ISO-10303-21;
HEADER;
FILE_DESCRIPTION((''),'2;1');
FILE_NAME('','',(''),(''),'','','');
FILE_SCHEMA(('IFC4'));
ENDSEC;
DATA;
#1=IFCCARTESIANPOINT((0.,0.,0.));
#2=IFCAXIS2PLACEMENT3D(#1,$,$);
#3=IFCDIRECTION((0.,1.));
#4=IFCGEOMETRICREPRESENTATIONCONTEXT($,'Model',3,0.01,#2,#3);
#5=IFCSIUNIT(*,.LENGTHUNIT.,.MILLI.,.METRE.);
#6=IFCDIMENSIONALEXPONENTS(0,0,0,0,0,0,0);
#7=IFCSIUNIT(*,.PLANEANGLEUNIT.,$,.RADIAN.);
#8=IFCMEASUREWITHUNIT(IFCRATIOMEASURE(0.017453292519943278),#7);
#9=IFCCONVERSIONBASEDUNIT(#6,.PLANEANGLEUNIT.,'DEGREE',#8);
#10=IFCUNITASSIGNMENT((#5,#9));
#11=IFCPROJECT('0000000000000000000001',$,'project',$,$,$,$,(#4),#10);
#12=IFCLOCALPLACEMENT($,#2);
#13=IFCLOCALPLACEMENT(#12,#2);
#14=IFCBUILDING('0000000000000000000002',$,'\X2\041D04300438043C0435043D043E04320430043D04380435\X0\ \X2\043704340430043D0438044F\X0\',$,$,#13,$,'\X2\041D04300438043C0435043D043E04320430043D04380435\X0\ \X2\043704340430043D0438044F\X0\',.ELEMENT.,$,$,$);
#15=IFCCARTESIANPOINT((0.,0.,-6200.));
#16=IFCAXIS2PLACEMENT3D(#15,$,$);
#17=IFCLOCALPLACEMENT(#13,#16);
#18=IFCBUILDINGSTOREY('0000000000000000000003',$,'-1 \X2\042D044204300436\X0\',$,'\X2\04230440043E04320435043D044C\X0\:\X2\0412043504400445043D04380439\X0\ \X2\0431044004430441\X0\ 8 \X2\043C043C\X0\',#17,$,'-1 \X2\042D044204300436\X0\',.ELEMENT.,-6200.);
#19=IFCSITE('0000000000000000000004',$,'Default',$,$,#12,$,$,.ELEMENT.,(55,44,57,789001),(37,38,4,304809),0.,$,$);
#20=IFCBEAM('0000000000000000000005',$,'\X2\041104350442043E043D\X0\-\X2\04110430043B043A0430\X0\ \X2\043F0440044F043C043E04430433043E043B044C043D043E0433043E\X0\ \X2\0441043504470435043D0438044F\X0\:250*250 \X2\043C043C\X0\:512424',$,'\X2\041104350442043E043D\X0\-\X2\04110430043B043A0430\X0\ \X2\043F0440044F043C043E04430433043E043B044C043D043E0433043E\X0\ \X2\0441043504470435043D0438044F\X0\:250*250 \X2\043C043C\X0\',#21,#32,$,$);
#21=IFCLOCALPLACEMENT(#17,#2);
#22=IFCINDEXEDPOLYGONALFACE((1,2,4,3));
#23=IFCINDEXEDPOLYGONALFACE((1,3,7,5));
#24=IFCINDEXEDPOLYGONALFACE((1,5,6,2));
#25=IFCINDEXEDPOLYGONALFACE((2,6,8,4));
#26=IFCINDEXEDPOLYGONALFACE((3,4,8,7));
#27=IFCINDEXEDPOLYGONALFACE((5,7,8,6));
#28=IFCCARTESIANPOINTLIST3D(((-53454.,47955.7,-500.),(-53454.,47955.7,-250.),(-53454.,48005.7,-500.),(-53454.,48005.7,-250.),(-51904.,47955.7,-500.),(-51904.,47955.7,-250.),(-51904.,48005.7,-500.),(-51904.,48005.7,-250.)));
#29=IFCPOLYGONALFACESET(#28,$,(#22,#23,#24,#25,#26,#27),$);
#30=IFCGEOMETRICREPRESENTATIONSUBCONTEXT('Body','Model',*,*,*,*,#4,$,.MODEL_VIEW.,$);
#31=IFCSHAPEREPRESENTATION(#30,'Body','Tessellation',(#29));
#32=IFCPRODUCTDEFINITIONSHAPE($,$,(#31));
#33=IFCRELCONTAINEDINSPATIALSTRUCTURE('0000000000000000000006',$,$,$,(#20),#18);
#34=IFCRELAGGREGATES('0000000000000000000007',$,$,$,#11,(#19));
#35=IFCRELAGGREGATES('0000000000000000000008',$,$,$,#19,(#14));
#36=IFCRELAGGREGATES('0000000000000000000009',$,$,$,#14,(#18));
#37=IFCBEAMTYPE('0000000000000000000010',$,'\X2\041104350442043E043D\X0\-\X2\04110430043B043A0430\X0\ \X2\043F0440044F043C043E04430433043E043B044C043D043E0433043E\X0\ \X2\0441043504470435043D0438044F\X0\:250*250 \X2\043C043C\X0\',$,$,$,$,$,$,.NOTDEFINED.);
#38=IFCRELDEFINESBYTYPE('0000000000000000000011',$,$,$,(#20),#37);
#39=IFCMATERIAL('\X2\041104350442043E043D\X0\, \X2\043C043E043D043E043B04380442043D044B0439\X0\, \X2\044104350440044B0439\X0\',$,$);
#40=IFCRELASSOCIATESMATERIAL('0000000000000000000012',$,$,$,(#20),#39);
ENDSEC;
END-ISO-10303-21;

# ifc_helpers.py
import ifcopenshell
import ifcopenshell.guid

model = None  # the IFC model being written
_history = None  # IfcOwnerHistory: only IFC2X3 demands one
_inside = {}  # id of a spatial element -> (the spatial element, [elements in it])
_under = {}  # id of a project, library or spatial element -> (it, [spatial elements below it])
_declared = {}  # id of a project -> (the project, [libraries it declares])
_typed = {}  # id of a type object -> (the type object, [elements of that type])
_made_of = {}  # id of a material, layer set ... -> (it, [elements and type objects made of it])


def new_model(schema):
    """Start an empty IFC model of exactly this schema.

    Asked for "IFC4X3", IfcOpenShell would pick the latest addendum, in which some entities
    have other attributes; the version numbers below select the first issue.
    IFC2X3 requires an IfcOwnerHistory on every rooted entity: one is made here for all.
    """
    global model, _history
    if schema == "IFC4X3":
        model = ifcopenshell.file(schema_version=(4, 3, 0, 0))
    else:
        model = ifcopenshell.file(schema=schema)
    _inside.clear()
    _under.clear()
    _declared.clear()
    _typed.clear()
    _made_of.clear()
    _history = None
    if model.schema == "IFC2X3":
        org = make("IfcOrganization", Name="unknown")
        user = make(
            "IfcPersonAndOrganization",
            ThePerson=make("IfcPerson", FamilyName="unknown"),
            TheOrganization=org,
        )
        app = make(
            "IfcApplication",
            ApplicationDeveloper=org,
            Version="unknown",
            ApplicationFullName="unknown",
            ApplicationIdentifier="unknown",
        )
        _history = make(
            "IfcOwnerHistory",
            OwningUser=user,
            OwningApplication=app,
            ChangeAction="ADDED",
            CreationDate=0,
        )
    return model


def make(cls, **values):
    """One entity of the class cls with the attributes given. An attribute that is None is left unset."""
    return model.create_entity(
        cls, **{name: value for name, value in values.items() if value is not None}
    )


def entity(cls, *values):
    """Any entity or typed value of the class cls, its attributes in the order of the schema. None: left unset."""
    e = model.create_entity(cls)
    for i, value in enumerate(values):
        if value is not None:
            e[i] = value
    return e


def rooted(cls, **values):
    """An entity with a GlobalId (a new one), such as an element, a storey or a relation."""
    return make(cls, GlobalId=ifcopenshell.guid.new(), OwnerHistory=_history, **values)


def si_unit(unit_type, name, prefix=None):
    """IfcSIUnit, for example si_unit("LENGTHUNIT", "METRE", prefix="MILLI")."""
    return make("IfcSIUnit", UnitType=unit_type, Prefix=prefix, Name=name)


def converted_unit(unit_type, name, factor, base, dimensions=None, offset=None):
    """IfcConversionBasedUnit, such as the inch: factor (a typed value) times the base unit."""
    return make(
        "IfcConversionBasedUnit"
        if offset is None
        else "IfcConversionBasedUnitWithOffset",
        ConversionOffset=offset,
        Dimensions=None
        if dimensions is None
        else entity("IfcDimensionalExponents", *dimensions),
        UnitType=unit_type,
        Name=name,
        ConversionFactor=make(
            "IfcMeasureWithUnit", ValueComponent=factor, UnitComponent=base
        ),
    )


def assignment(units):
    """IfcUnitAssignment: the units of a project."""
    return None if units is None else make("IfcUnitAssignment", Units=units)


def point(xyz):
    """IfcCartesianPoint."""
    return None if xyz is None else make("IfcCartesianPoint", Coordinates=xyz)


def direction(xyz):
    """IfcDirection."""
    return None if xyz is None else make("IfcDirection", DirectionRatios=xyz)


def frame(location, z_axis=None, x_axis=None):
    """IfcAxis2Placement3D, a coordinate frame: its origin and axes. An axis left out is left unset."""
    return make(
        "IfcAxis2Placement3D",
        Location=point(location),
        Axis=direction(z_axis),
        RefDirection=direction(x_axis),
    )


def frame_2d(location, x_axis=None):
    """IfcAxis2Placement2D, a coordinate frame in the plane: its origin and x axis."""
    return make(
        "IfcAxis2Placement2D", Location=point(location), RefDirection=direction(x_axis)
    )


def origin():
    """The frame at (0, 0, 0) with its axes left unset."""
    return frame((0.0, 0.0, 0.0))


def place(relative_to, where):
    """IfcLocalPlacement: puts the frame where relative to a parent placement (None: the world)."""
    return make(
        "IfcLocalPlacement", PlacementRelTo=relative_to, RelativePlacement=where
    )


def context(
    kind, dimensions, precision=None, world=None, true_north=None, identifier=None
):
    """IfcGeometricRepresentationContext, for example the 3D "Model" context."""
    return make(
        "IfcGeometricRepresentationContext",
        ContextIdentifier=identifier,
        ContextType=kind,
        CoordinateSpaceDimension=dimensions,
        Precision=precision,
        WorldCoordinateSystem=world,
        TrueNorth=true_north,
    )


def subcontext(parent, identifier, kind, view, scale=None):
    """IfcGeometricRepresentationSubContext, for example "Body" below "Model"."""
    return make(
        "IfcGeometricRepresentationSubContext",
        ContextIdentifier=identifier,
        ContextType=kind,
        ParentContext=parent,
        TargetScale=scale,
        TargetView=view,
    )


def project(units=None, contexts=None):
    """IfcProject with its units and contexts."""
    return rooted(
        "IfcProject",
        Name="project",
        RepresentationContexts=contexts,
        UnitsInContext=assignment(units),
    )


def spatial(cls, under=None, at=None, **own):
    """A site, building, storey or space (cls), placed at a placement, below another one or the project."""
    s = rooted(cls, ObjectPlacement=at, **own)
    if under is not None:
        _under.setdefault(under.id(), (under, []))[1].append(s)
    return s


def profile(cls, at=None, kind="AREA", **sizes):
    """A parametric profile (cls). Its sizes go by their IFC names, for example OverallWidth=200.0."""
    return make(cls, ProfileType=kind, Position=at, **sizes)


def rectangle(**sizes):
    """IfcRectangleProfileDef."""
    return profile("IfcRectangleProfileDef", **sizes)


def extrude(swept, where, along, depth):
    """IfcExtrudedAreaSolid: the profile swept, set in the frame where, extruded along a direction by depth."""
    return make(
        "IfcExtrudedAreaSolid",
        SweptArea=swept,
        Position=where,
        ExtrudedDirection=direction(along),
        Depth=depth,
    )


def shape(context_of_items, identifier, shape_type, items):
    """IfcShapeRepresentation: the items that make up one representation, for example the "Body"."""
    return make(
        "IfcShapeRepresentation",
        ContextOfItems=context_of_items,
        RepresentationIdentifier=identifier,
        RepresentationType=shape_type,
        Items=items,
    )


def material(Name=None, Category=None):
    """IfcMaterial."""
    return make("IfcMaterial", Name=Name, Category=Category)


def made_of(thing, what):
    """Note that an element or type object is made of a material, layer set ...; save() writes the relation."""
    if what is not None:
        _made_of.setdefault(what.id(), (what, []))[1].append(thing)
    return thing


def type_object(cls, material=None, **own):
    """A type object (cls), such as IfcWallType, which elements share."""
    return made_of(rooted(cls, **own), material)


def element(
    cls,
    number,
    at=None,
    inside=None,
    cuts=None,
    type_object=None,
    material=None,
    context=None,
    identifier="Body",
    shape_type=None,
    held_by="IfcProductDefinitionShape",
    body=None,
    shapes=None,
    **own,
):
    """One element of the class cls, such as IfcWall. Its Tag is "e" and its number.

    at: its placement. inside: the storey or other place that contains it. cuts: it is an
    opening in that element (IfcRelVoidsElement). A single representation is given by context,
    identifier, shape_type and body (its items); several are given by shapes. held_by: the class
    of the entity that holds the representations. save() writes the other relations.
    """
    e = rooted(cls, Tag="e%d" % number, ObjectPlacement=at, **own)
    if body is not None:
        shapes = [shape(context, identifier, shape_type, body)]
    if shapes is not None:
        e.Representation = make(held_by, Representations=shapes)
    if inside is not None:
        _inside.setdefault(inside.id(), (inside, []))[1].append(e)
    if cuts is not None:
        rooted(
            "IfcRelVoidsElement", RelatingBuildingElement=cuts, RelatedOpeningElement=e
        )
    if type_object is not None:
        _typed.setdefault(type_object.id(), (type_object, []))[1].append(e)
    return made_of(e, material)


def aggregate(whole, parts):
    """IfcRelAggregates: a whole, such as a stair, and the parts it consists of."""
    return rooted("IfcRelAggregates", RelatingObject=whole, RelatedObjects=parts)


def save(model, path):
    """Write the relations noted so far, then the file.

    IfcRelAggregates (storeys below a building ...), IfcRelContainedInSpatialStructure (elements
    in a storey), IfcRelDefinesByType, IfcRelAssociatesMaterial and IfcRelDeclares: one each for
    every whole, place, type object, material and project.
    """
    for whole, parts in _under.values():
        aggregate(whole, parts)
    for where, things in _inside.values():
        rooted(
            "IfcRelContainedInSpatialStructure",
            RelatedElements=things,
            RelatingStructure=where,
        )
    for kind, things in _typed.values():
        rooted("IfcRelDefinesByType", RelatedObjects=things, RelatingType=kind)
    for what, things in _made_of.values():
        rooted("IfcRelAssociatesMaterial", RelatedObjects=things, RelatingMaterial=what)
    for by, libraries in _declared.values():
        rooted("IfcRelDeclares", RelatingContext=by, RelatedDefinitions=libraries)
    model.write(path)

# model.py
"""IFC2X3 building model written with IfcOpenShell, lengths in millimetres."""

from ifc_helpers import new_model, entity, si_unit, converted_unit, direction, frame, frame_2d, origin, place, context, subcontext, project, spatial, rectangle, extrude, material, type_object, element, save


model = new_model("IFC2X3")

# Units and contexts
model_context = context("Model", 3, precision=0.01, world=origin(), true_north=direction((0.0, 1.0)))
body_context = subcontext(model_context, "Body", "Model", "MODEL_VIEW")
ifc_project = project(units=[si_unit("LENGTHUNIT", "METRE", prefix="MILLI"), converted_unit("PLANEANGLEUNIT", "DEGREE", entity("IfcRatioMeasure", 0.017453292519943278), si_unit("PLANEANGLEUNIT", "RADIAN"), dimensions=[0, 0, 0, 0, 0, 0, 0])], contexts=[model_context])

# Site, building, storey
site_placement = place(None, origin())
site = spatial("IfcSite", under=ifc_project, at=site_placement, Name="Default", CompositionType="ELEMENT", RefLatitude=(55, 44, 57, 789001), RefLongitude=(37, 38, 4, 304809), RefElevation=0.0)
building_placement = place(site_placement, origin())
building = spatial("IfcBuilding", under=site, at=building_placement, Name="Наименование здания", LongName="Наименование здания", CompositionType="ELEMENT")
storey_placement = place(building_placement, frame((0.0, 0.0, -6200.0)))
storey = spatial("IfcBuildingStorey", under=building, at=storey_placement, Name="-1 Этаж", ObjectType="Уровень:Верхний брус 8 мм", LongName="-1 Этаж", CompositionType="ELEMENT", Elevation=-6200.0)

# Beam
ifc_material_1 = material(Name="Бетон, монолитный, серый")
beam_type = type_object("IfcBeamType", Name="Бетон-Балка прямоугольного сечения:250*250 мм", PredefinedType="NOTDEFINED")
beam_placement = place(storey_placement, frame((-51904.0, 47955.7, 0.0), z_axis=(0.0, 0.0, 1.0), x_axis=(-1.0, 0.0, 0.0)))
element("IfcBeam", 1, at=beam_placement, inside=storey, type_object=beam_type, material=ifc_material_1, Name="Бетон-Балка прямоугольного сечения:250*250 мм:512424", ObjectType="Бетон-Балка прямоугольного сечения:250*250 мм", context=body_context, shape_type="SweptSolid", body=[
    extrude(rectangle(XDim=250.0, YDim=50.0, at=frame_2d((0.0, 0.0), x_axis=(1.0, 0.0))), frame((0.0, -25.0, -375.0), z_axis=(1.0, 0.0, 0.0), x_axis=(0.0, 0.0, -1.0)), (0.0, 0.0, 1.0), 1550.0),
])

save(model, "model.ifc")
